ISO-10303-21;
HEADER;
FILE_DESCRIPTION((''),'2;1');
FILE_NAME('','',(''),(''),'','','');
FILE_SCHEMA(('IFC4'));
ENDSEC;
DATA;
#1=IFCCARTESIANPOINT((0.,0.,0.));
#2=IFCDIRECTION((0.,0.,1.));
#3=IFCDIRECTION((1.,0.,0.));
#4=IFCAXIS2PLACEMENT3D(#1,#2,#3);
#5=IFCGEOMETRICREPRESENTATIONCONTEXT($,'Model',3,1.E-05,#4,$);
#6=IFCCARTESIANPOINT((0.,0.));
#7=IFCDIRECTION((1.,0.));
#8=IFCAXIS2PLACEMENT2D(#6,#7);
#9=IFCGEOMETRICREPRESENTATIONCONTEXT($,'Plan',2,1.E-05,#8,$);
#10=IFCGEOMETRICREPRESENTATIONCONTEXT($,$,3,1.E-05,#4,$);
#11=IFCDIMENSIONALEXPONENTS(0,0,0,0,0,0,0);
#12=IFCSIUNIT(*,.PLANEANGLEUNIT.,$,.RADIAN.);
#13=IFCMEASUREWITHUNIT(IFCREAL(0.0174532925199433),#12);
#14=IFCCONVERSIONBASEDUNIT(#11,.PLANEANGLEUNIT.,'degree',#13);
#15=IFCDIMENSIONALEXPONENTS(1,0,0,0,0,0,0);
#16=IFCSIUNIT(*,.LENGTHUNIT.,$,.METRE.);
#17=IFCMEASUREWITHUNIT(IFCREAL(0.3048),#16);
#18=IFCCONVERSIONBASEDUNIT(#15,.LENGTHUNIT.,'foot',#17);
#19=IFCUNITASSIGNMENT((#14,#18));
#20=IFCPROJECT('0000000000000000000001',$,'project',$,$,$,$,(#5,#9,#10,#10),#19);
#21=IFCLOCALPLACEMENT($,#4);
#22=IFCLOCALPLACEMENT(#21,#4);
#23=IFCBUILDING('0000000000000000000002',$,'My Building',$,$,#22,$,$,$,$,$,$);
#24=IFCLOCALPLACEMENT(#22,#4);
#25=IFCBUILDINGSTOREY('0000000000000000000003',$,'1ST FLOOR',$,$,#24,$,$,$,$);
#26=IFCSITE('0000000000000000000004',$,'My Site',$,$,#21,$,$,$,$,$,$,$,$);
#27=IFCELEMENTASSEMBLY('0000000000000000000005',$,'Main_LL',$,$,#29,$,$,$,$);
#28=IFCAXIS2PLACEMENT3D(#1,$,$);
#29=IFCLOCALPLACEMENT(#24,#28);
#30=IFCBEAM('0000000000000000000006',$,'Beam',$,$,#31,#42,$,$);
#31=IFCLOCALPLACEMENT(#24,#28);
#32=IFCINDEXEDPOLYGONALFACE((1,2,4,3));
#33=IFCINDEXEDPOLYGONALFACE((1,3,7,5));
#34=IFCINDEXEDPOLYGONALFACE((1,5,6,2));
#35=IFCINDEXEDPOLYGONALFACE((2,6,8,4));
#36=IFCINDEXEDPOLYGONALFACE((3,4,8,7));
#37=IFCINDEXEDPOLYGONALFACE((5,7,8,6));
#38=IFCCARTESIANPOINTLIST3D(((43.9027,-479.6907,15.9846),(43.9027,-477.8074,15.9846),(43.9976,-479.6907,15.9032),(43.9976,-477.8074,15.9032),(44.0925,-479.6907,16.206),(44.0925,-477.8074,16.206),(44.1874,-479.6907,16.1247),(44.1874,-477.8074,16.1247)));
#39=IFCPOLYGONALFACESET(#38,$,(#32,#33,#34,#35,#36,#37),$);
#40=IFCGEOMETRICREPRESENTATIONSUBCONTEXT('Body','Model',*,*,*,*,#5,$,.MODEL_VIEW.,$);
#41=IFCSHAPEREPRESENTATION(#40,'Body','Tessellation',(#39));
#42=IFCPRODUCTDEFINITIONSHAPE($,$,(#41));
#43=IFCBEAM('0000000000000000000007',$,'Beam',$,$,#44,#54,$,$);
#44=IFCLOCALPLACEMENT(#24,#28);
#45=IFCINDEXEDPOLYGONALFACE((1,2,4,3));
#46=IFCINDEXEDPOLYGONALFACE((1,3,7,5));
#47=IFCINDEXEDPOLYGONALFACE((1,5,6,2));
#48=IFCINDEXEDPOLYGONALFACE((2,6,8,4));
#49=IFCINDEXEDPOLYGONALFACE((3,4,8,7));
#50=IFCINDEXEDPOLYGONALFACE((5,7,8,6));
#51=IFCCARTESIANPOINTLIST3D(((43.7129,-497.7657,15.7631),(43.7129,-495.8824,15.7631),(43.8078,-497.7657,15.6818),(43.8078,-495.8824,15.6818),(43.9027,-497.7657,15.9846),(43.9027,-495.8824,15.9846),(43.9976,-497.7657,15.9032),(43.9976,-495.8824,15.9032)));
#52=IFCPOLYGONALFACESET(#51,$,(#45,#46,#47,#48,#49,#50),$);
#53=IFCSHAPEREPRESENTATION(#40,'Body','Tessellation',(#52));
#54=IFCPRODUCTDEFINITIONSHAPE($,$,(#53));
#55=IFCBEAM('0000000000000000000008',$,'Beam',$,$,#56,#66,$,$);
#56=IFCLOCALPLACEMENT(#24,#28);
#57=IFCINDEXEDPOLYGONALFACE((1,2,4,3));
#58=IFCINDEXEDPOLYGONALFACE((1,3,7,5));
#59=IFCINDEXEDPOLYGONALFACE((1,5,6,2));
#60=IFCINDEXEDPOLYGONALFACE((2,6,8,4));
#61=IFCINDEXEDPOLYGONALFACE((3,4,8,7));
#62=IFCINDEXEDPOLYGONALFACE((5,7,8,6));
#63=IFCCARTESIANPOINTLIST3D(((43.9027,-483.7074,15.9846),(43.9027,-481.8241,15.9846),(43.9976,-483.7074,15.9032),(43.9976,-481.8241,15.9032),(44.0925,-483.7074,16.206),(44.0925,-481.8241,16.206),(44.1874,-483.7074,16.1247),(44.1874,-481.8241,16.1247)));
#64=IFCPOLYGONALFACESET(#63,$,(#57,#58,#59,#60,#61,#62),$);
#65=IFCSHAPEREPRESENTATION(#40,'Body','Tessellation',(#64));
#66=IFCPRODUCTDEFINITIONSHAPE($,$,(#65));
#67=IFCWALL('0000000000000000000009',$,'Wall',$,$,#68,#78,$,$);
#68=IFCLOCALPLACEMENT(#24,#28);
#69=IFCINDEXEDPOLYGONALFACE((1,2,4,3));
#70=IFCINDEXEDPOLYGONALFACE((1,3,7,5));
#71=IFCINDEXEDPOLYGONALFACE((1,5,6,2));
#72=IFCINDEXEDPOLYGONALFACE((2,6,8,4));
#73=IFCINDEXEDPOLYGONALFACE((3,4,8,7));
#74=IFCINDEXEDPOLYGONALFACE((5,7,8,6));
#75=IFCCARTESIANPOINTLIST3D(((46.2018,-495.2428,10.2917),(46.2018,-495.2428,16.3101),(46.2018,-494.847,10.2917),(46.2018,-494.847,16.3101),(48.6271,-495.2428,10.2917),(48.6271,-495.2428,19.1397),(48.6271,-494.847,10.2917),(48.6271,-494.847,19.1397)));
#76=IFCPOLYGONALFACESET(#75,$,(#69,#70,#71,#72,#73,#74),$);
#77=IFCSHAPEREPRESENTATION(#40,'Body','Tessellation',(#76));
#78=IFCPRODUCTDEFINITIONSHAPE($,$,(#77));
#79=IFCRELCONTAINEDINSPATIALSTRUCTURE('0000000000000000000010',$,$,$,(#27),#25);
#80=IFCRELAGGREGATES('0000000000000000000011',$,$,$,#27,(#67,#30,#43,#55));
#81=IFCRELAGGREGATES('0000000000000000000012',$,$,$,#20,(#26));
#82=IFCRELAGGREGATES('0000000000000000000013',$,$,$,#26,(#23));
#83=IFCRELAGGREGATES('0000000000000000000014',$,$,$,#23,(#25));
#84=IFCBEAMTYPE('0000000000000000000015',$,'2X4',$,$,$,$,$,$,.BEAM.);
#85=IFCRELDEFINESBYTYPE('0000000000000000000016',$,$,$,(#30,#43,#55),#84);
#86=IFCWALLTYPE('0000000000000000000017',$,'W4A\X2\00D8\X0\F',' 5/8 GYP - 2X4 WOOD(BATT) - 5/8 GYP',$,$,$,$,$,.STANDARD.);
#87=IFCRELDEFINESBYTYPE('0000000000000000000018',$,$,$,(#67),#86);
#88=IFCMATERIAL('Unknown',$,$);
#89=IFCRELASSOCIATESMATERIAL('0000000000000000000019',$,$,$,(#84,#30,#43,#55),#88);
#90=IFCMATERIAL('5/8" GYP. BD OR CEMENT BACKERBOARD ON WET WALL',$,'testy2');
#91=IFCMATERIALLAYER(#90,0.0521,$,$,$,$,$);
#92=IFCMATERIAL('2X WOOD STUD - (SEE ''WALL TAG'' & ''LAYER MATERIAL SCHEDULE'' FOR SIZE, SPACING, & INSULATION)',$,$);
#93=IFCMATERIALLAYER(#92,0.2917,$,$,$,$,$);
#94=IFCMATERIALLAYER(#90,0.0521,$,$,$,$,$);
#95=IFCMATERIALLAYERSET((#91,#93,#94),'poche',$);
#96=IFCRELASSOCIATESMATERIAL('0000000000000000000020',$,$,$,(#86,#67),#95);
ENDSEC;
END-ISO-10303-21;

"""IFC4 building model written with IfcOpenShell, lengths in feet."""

from ifc_helpers import new_model, entity, si_unit, converted_unit, frame, origin_with_axes, origin_2d_with_axis, place, context, subcontext, project, spatial, indexed_curve, rectangle, outline, extrude, clip, halfspace, material, layer, layer_set, layer_usage, material_profile, profile_set, profile_usage, type_object, element, aggregate, save


model = new_model("IFC4")

# Units and contexts
model_context = context("Model", 3, precision=1e-05, world=origin_with_axes())
plan_context = context("Plan", 2, precision=1e-05, world=origin_2d_with_axis())
context_of_model = context(None, 3, precision=1e-05, world=origin_with_axes())
body_context = subcontext(model_context, "Body", "Model", "MODEL_VIEW")
ifc_project = project(units=[converted_unit("PLANEANGLEUNIT", "degree", entity("IfcReal", 0.0174532925199433), si_unit("PLANEANGLEUNIT", "RADIAN"), dimensions=[0, 0, 0, 0, 0, 0, 0]), converted_unit("LENGTHUNIT", "foot", entity("IfcReal", 0.3048), si_unit("LENGTHUNIT", "METRE"), dimensions=[1, 0, 0, 0, 0, 0, 0])], contexts=[model_context, plan_context, context_of_model, context_of_model])

# Site, building, storey
site_placement = place(None, origin_with_axes())
site = spatial("IfcSite", under=ifc_project, at=site_placement, Name="My Site")
building_placement = place(site_placement, origin_with_axes())
building = spatial("IfcBuilding", under=site, at=building_placement, Name="My Building")
storey_placement = place(building_placement, origin_with_axes())
storey = spatial("IfcBuildingStorey", under=building, at=storey_placement, Name="1ST FLOOR")

# Element assembly, beams, wall
assembly_placement = place(storey_placement, origin_with_axes())
assembly = element("IfcElementAssembly", 1, at=assembly_placement, inside=storey, Name="Main_LL")
ifc_material_1 = material(Name="Unknown")
ifc_material_profile_1 = material_profile(ifc_material_1, rectangle(XDim=0.125, YDim=0.2917))
ifc_profile_set_1 = profile_set([ifc_material_profile_1])
beam_type_1 = type_object("IfcBeamType", Name="2X4", PredefinedType="BEAM", material=ifc_profile_set_1)
ifc_profile_usage_1 = profile_usage(ifc_profile_set_1, cardinal=5)
beam_1_placement = place(assembly_placement, frame((44.045, -477.8074, 16.0546), z_axis=(0.0, -1.0, 0.0), x_axis=(-0.759271, 0.0, 0.650774)))
beam_1 = element("IfcBeam", 2, at=beam_1_placement, type_object=beam_type_1, material=ifc_profile_usage_1, Name="Beam", context=body_context, shape_type="SweptSolid", body=[
    extrude(rectangle(XDim=0.125, YDim=0.2917), origin_with_axes(), (0.0, 0.0, 1.0), 1.8833),
])
ifc_profile_usage_2 = profile_usage(ifc_profile_set_1, cardinal=5)
beam_2_placement = place(assembly_placement, frame((43.8552, -495.8824, 15.8332), z_axis=(0.0, -1.0, 0.0), x_axis=(-0.759271, 0.0, 0.650774)))
beam_2 = element("IfcBeam", 3, at=beam_2_placement, type_object=beam_type_1, material=ifc_profile_usage_2, Name="Beam", context=body_context, shape_type="SweptSolid", body=[
    extrude(rectangle(XDim=0.125, YDim=0.2917), origin_with_axes(), (0.0, 0.0, 1.0), 1.8833),
])
ifc_profile_usage_3 = profile_usage(ifc_profile_set_1, cardinal=5)
beam_3_placement = place(assembly_placement, frame((44.045, -481.8241, 16.0546), z_axis=(0.0, -1.0, 0.0), x_axis=(-0.759271, 0.0, 0.650774)))
beam_3 = element("IfcBeam", 4, at=beam_3_placement, type_object=beam_type_1, material=ifc_profile_usage_3, Name="Beam", context=body_context, shape_type="SweptSolid", body=[
    extrude(rectangle(XDim=0.125, YDim=0.2917), origin_with_axes(), (0.0, 0.0, 1.0), 1.8833),
])
ifc_material_2 = material(Name="5/8\" GYP. BD OR CEMENT BACKERBOARD ON WET WALL", Category="testy2")
ifc_layer_1 = layer(ifc_material_2, 0.0521)
ifc_material_3 = material(Name="2X WOOD STUD - (SEE 'WALL TAG' & 'LAYER MATERIAL SCHEDULE' FOR SIZE, SPACING, & INSULATION)")
ifc_layer_2 = layer(ifc_material_3, 0.2917)
ifc_layer_3 = layer(ifc_material_2, 0.0521)
ifc_layer_set = layer_set([ifc_layer_1, ifc_layer_2, ifc_layer_3], Name="poche")
ifc_layer_usage_1 = layer_usage(ifc_layer_set, "AXIS2", "POSITIVE", 0.0)
wall_type = type_object("IfcWallType", Name="W4AØF", Description=" 5/8 GYP - 2X4 WOOD(BATT) - 5/8 GYP", PredefinedType="STANDARD", material=ifc_layer_set)
wall_1_placement = place(assembly_placement, frame((46.2018, -495.2428, 10.2917), z_axis=(0.0, 0.0, 1.0), x_axis=(1.0, 0.0, 0.0)))
wall_1 = element("IfcWall", 5, at=wall_1_placement, type_object=wall_type, material=ifc_layer_usage_1, Name="Wall", context=body_context, shape_type="Clipping", body=[
    clip(extrude(outline(indexed_curve([(0.0, 0.0), (0.0, 0.3958), (2.4253, 0.3958), (2.4253, 0.0), (0.0, 0.0)], self_intersect=False)), origin_with_axes(), (0.0, 0.0, 1.0), 19.1397), halfspace(frame((2.4253, 0.0, 8.8481), z_axis=(-0.759271, 0.0, 0.650774), x_axis=(0.0, 1.0, 0.0)), False)),
])
aggregate(assembly, [wall_1, beam_1, beam_2, beam_3])

save(model, "model.ifc")
